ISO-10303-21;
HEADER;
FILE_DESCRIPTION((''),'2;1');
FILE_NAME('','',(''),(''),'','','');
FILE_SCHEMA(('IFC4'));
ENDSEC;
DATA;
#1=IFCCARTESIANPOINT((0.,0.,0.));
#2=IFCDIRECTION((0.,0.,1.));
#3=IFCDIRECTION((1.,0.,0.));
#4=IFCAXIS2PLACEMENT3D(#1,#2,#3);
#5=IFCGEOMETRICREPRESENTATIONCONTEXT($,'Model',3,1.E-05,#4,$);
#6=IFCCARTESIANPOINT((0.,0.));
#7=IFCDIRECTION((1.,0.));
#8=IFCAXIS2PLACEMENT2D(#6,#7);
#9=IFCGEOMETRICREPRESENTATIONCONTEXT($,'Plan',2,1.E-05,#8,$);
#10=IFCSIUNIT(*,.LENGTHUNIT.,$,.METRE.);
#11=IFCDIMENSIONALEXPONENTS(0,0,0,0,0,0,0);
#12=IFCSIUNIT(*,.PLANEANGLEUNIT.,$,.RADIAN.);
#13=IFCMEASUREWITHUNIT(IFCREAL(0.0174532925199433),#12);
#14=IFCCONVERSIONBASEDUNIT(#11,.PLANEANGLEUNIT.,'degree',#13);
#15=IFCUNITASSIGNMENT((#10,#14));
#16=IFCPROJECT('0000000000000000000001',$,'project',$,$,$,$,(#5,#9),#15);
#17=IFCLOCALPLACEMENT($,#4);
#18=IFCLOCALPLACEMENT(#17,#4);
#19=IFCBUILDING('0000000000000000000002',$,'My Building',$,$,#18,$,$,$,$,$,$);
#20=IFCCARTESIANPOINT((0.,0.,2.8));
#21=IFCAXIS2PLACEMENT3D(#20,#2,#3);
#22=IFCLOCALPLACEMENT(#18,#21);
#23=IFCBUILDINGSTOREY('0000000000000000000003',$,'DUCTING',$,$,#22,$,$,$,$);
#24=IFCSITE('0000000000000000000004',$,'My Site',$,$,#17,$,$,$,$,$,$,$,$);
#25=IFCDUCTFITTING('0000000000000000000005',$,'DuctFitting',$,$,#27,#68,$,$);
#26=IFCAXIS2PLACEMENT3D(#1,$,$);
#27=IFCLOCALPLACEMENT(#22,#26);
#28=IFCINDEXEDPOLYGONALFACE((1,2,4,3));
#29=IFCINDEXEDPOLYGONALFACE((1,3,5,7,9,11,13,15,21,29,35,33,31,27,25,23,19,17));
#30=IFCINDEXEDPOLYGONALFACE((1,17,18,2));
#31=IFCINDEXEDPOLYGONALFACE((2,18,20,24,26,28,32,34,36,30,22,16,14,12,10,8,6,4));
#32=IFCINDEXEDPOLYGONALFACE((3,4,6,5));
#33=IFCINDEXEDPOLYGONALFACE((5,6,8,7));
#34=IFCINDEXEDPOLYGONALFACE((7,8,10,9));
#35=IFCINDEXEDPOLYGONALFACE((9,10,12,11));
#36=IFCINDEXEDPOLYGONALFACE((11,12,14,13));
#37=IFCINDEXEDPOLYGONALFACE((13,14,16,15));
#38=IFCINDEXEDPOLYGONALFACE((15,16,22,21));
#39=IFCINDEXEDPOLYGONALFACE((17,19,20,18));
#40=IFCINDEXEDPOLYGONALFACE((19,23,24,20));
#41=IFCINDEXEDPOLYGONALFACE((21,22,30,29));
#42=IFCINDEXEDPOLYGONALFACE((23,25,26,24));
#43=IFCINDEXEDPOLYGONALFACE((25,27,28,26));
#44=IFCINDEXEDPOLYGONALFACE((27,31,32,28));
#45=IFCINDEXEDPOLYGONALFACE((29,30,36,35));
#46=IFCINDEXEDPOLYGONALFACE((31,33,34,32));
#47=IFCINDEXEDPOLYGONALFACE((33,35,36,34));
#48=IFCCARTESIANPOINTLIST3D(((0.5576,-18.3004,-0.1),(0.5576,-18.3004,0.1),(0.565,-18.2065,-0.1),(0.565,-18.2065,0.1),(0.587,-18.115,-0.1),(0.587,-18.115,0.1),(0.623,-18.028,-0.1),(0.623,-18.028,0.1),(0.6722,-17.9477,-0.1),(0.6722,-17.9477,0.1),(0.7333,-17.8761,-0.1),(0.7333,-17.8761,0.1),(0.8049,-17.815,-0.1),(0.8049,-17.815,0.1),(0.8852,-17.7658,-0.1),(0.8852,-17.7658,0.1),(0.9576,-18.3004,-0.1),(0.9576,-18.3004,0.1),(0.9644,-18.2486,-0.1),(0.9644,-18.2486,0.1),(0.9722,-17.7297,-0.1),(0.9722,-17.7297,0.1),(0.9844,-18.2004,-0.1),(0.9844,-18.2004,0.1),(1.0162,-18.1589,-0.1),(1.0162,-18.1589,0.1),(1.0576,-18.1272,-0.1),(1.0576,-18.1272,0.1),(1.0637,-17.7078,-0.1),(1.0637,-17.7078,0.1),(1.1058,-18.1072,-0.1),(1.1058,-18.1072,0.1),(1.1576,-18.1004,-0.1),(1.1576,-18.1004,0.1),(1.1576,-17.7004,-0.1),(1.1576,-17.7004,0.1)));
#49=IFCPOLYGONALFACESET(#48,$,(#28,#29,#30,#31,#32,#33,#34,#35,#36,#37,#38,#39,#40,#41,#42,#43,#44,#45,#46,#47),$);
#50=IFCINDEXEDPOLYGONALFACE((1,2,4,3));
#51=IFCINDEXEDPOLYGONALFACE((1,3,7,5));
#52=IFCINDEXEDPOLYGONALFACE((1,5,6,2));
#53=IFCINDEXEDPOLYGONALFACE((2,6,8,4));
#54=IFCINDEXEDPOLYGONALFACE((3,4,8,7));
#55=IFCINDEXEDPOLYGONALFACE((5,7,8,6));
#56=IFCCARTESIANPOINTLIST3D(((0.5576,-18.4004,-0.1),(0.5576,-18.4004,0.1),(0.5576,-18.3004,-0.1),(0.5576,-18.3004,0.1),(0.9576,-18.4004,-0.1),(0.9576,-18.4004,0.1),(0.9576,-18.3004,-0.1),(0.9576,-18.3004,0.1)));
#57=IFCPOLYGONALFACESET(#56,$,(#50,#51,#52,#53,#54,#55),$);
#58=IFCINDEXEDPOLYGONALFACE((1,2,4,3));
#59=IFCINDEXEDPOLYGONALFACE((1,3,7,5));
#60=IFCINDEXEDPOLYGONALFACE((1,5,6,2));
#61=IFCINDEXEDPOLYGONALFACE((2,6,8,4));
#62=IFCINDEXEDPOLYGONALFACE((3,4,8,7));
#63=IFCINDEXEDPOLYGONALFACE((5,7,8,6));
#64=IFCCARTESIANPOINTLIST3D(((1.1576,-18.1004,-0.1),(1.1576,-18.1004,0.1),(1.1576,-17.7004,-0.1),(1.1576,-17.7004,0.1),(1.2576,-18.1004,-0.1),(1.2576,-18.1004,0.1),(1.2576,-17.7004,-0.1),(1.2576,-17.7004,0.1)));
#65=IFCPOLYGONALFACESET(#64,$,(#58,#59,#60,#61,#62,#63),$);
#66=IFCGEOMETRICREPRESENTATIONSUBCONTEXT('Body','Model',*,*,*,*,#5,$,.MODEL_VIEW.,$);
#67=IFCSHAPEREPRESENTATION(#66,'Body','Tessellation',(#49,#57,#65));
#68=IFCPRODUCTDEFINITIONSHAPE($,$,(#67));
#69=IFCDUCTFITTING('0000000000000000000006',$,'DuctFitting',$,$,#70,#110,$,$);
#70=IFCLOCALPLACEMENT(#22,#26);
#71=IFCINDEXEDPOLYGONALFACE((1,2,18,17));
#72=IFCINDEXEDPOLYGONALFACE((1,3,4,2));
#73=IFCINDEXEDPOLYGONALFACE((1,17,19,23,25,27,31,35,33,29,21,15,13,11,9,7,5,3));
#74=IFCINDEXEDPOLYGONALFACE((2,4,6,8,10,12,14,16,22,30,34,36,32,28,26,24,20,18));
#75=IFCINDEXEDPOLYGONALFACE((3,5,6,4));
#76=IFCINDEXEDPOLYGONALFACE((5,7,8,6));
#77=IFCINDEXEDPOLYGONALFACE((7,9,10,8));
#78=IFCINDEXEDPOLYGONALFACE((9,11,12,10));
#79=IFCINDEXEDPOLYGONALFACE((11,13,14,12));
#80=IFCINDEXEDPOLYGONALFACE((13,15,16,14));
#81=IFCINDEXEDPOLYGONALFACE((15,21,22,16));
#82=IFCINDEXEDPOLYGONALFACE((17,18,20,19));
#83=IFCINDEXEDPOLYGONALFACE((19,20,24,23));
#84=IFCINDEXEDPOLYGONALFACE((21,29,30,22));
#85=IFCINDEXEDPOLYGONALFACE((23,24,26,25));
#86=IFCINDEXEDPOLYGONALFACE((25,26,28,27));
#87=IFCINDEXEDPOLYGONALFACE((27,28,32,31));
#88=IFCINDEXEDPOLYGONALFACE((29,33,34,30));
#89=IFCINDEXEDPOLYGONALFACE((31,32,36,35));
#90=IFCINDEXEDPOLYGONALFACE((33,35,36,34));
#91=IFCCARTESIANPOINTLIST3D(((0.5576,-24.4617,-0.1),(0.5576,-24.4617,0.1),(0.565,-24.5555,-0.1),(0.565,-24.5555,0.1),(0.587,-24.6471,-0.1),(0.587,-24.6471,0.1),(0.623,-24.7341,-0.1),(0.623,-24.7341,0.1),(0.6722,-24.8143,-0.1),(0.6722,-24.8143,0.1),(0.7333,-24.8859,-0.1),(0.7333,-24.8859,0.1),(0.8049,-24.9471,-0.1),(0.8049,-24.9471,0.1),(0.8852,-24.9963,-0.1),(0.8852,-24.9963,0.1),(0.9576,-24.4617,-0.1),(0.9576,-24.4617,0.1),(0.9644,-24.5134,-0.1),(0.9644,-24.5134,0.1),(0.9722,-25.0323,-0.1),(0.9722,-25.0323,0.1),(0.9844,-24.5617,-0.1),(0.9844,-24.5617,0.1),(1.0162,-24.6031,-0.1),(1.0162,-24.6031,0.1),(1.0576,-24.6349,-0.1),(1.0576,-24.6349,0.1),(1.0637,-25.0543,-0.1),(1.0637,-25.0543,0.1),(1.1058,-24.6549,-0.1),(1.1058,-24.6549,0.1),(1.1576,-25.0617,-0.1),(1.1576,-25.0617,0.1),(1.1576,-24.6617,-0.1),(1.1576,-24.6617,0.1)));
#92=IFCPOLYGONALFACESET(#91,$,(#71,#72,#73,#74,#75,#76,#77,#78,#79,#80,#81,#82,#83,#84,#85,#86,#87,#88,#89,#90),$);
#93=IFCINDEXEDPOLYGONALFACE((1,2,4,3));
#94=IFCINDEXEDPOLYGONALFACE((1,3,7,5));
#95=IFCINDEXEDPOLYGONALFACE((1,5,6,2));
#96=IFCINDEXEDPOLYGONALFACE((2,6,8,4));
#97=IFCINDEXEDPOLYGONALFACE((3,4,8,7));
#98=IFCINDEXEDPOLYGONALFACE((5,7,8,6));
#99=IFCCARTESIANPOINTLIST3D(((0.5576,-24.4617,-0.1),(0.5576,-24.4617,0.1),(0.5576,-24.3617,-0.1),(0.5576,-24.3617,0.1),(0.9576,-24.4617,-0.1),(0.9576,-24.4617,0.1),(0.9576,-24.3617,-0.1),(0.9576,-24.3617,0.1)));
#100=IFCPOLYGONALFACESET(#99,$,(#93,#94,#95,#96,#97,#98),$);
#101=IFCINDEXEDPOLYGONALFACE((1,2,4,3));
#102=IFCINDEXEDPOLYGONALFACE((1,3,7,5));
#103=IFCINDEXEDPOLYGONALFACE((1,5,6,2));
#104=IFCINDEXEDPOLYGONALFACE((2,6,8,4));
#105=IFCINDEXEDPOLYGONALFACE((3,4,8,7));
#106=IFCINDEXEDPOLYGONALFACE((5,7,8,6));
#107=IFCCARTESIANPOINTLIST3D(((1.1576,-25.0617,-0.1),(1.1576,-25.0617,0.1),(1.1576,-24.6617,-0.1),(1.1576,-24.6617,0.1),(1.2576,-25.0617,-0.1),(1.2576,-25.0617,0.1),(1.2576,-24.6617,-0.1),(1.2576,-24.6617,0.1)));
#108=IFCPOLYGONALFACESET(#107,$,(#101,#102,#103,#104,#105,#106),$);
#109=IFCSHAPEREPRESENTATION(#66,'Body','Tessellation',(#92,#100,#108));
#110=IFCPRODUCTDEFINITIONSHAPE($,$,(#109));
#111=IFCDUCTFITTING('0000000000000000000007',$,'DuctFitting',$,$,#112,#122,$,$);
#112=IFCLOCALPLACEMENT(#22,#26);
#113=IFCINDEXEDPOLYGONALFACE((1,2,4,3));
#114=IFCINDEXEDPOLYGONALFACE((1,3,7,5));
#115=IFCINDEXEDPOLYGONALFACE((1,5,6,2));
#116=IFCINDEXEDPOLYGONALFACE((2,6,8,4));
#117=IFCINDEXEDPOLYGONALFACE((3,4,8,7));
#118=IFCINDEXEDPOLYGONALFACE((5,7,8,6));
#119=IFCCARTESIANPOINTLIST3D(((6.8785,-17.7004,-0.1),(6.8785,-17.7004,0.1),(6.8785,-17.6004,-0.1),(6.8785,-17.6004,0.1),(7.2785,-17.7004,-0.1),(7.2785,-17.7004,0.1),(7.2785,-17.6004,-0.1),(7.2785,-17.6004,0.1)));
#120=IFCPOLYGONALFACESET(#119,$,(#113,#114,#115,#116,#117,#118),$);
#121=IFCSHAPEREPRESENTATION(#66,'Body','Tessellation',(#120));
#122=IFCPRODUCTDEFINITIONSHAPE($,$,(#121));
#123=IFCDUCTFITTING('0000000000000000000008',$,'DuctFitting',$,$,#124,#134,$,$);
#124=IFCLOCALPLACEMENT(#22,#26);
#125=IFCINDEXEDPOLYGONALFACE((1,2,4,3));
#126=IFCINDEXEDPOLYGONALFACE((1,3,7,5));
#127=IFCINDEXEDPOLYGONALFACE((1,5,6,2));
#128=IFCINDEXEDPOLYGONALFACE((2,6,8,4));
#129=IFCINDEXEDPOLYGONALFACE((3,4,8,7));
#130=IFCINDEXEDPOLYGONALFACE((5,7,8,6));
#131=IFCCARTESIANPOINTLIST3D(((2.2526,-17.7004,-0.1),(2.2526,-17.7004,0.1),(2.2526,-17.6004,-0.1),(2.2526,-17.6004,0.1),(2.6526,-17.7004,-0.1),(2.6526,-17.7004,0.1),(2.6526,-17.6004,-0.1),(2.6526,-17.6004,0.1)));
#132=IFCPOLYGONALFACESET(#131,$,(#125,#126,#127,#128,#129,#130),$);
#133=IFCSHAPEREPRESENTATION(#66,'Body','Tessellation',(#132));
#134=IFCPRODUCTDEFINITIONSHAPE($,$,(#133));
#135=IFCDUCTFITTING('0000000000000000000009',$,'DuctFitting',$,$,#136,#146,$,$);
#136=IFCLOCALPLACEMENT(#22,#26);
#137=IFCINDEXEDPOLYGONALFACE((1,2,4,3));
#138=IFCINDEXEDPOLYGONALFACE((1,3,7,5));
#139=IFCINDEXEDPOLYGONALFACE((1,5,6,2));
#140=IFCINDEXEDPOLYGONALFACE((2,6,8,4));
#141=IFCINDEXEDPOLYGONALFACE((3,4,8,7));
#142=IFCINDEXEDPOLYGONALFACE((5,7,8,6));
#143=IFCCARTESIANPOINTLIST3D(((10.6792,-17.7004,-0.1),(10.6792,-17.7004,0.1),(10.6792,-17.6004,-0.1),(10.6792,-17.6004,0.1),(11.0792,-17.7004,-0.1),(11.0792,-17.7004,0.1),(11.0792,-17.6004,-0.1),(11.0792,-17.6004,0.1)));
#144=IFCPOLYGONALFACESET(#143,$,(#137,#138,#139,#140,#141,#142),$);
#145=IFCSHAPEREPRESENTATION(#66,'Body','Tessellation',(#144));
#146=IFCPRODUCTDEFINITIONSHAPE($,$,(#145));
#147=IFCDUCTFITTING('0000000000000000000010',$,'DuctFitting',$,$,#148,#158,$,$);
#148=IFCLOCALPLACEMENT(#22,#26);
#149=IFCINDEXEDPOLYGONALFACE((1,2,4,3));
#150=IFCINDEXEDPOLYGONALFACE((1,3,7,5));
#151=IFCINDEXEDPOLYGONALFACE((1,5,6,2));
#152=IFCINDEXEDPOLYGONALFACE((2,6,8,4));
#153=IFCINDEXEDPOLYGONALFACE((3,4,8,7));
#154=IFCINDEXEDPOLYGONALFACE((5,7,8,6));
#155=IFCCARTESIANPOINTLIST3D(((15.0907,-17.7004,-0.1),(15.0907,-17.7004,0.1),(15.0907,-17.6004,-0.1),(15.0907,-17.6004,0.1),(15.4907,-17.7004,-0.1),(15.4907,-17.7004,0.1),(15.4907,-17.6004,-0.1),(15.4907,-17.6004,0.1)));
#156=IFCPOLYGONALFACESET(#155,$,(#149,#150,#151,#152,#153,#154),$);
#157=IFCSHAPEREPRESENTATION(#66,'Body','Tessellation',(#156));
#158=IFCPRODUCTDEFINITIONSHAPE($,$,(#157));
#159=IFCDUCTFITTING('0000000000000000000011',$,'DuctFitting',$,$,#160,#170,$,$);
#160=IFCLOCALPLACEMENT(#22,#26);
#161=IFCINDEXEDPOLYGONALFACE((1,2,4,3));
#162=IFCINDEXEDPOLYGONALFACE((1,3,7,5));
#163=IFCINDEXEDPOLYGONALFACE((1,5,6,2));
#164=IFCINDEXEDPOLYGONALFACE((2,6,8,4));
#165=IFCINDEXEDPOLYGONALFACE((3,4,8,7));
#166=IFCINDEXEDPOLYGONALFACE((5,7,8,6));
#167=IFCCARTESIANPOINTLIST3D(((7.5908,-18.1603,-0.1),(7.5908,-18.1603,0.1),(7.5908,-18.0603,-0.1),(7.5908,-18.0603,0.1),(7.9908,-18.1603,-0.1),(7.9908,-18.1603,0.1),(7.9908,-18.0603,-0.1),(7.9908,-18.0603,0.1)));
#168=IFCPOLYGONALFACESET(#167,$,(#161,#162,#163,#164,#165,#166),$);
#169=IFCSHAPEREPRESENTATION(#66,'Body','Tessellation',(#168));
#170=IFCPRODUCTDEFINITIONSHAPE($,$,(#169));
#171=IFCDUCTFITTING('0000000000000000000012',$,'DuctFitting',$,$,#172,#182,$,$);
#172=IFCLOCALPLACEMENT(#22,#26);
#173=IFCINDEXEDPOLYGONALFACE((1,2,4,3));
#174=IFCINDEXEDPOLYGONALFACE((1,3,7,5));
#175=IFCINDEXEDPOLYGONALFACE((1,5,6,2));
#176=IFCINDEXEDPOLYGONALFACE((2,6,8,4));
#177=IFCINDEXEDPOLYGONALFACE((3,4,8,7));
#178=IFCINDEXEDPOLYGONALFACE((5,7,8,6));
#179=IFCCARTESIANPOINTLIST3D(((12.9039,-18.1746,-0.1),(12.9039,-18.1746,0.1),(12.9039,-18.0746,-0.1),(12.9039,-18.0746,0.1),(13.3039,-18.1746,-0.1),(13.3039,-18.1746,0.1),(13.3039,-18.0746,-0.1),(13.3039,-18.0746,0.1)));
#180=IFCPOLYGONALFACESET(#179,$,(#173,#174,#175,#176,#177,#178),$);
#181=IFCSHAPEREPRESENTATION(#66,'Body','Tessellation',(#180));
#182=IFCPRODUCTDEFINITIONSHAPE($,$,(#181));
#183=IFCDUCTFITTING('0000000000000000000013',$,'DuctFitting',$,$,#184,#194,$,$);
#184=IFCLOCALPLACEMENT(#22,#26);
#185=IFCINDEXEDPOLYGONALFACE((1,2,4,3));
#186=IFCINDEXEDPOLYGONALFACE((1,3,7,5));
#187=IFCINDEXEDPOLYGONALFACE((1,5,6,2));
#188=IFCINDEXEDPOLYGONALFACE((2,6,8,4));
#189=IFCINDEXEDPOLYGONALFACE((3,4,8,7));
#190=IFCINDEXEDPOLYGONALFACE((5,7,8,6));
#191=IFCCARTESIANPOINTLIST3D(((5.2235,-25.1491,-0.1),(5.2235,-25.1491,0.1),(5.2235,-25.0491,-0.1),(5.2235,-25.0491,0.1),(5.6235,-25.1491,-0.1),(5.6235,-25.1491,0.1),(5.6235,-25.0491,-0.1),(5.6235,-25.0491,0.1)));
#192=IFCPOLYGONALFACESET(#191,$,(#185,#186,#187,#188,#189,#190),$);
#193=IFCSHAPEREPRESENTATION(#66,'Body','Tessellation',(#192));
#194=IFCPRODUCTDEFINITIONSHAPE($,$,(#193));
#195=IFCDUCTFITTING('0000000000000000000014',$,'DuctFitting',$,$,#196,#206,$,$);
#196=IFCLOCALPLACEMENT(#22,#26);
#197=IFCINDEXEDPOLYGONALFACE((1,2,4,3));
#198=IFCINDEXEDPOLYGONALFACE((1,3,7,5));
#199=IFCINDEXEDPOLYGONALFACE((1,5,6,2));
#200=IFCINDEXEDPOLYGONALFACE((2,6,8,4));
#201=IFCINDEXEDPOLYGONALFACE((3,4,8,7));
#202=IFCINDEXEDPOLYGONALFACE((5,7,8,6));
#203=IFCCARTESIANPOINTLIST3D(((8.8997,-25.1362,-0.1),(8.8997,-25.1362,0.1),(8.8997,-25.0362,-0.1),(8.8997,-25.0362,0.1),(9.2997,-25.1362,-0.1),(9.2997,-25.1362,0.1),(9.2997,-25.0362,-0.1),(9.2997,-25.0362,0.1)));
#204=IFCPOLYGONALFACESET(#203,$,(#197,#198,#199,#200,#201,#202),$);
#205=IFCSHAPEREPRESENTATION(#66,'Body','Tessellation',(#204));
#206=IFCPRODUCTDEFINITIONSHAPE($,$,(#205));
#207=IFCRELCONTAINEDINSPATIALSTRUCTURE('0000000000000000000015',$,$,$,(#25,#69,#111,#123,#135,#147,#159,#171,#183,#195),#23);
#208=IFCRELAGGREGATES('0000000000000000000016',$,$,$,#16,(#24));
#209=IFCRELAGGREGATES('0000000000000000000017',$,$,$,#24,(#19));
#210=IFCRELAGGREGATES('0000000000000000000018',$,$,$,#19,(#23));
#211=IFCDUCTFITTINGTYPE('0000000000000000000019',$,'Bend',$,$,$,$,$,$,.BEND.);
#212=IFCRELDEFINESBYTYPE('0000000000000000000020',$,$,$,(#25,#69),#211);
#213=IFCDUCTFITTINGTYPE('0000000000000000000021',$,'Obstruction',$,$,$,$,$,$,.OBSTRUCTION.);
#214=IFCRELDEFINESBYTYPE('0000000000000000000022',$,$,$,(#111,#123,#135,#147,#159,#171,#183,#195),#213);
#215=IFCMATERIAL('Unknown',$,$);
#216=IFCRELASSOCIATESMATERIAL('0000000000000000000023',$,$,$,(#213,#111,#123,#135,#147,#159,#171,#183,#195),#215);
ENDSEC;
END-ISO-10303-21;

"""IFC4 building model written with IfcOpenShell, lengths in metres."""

from ifc_helpers import new_model, entity, si_unit, converted_unit, frame, origin_with_axes, origin_2d_with_axis, place, context, subcontext, project, spatial, line, arc, indexed_curve, rectangle, outline, extrude, source, transform, mapped, material, material_profile, profile_set, profile_usage, type_object, type_shapes, element, save


model = new_model("IFC4")

# Units and contexts
model_context = context("Model", 3, precision=1e-05, world=origin_with_axes())
plan_context = context("Plan", 2, precision=1e-05, world=origin_2d_with_axis())
body_context = subcontext(model_context, "Body", "Model", "MODEL_VIEW")
ifc_project = project(units=[si_unit("LENGTHUNIT", "METRE"), converted_unit("PLANEANGLEUNIT", "degree", entity("IfcReal", 0.0174532925199433), si_unit("PLANEANGLEUNIT", "RADIAN"), dimensions=[0, 0, 0, 0, 0, 0, 0])], contexts=[model_context, plan_context])

# Site, building, storey
site_placement = place(None, origin_with_axes())
site = spatial("IfcSite", under=ifc_project, at=site_placement, Name="My Site")
building_placement = place(site_placement, origin_with_axes())
building = spatial("IfcBuilding", under=site, at=building_placement, Name="My Building")
storey_placement = place(building_placement, frame((0.0, 0.0, 2.8), z_axis=(0.0, 0.0, 1.0), x_axis=(1.0, 0.0, 0.0)))
storey = spatial("IfcBuildingStorey", under=building, at=storey_placement, Name="DUCTING")

# Shared definitions
ifc_material = material(Name="Unknown")

# Duct fittings
duct_fitting_type_1 = type_object("IfcDuctFittingType", Name="Bend", PredefinedType="BEND")
shared_shape = source(origin_with_axes(), body_context, "Body", "SweptSolid", [
    extrude(outline(indexed_curve([(-0.2, 0.0), (-0.2586, 0.1414), (-0.4, 0.2), (-0.4, 0.6), (0.0243, 0.4243), (0.2, 0.0)], segments=[arc(1, 2, 3), line(3, 4), arc(4, 5, 6), line(6, 1)])), frame((0.0, -0.1, 0.1), z_axis=(0.0, -1.0, 0.0), x_axis=(1.0, 0.0, 0.0)), (0.0, 0.0, -1.0), 0.2),
    extrude(rectangle(XDim=0.4, YDim=0.2), origin_with_axes(), (0.0, 0.0, 1.0), 0.1),
    extrude(rectangle(XDim=0.4, YDim=0.2), frame((-0.4, 0.0, 0.5), z_axis=(-1.0, 0.0, 0.0), x_axis=(0.0, 0.0, -1.0)), (0.0, 0.0, 1.0), 0.1),
])
type_shapes(duct_fitting_type_1, [shared_shape])
for number, where, z_axis, x_axis, name in (
    (1, (0.7576, -18.4004, 0.0), (0.0, 1.0, 0.0), (-1.0, 0.0, 0.0), "DuctFitting"),
    (2, (0.7576, -24.3617, 0.0), (0.0, -1.0, 0.0), (-1.0, 0.0, 0.0), "DuctFitting"),
):
    element("IfcDuctFitting", number, at=place(storey_placement, frame(where, z_axis=z_axis, x_axis=x_axis)), inside=storey, type_object=duct_fitting_type_1, Name=name, context=body_context, shape_type="MappedRepresentation", body=[
        mapped(shared_shape, transform((0.0, 0.0, 0.0), x_axis=(1.0, 0.0, 0.0), y_axis=(0.0, 1.0, 0.0), z_axis=(0.0, 0.0, 1.0), scale=1.0)),
    ])
ifc_material_profile_1 = material_profile(ifc_material, rectangle(XDim=0.4, YDim=0.2))
ifc_profile_set_1 = profile_set([ifc_material_profile_1])
ifc_profile_usage_1 = profile_usage(ifc_profile_set_1, cardinal=5)
duct_fitting_type_2 = type_object("IfcDuctFittingType", Name="Obstruction", PredefinedType="OBSTRUCTION", material=ifc_profile_set_1)
duct_fitting_1_placement = place(storey_placement, frame((7.0785, -17.7004, 0.0), z_axis=(0.0, 1.0, 0.0), x_axis=(-1.0, 0.0, 0.0)))
element("IfcDuctFitting", 3, at=duct_fitting_1_placement, inside=storey, type_object=duct_fitting_type_2, material=ifc_profile_usage_1, Name="DuctFitting", context=body_context, shape_type="SweptSolid", body=[
    extrude(rectangle(XDim=0.4, YDim=0.2), origin_with_axes(), (0.0, 0.0, 1.0), 0.1),
])
ifc_profile_usage_2 = profile_usage(ifc_profile_set_1, cardinal=5)
duct_fitting_2_placement = place(storey_placement, frame((2.4526, -17.7004, 0.0), z_axis=(0.0, 1.0, 0.0), x_axis=(-1.0, 0.0, 0.0)))
element("IfcDuctFitting", 4, at=duct_fitting_2_placement, inside=storey, type_object=duct_fitting_type_2, material=ifc_profile_usage_2, Name="DuctFitting", context=body_context, shape_type="SweptSolid", body=[
    extrude(rectangle(XDim=0.4, YDim=0.2), origin_with_axes(), (0.0, 0.0, 1.0), 0.1),
])
ifc_profile_usage_3 = profile_usage(ifc_profile_set_1, cardinal=5)
duct_fitting_3_placement = place(storey_placement, frame((10.8792, -17.7004, 0.0), z_axis=(0.0, 1.0, 0.0), x_axis=(-1.0, 0.0, 0.0)))
element("IfcDuctFitting", 5, at=duct_fitting_3_placement, inside=storey, type_object=duct_fitting_type_2, material=ifc_profile_usage_3, Name="DuctFitting", context=body_context, shape_type="SweptSolid", body=[
    extrude(rectangle(XDim=0.4, YDim=0.2), origin_with_axes(), (0.0, 0.0, 1.0), 0.1),
])
ifc_profile_usage_4 = profile_usage(ifc_profile_set_1, cardinal=5)
duct_fitting_4_placement = place(storey_placement, frame((15.2907, -17.7004, 0.0), z_axis=(0.0, 1.0, 0.0), x_axis=(-1.0, 0.0, 0.0)))
element("IfcDuctFitting", 6, at=duct_fitting_4_placement, inside=storey, type_object=duct_fitting_type_2, material=ifc_profile_usage_4, Name="DuctFitting", context=body_context, shape_type="SweptSolid", body=[
    extrude(rectangle(XDim=0.4, YDim=0.2), origin_with_axes(), (0.0, 0.0, 1.0), 0.1),
])
ifc_profile_usage_5 = profile_usage(ifc_profile_set_1, cardinal=5)
duct_fitting_5_placement = place(storey_placement, frame((7.7908, -18.1603, 0.0), z_axis=(-0.000001, 1.0, 0.0), x_axis=(-1.0, -0.000001, 0.0)))
element("IfcDuctFitting", 7, at=duct_fitting_5_placement, inside=storey, type_object=duct_fitting_type_2, material=ifc_profile_usage_5, Name="DuctFitting", context=body_context, shape_type="SweptSolid", body=[
    extrude(rectangle(XDim=0.4, YDim=0.2), origin_with_axes(), (0.0, 0.0, 1.0), 0.1),
])
ifc_profile_usage_6 = profile_usage(ifc_profile_set_1, cardinal=5)
duct_fitting_6_placement = place(storey_placement, frame((13.1039, -18.1746, 0.0), z_axis=(-0.000001, 1.0, 0.0), x_axis=(-1.0, -0.000001, 0.0)))
element("IfcDuctFitting", 8, at=duct_fitting_6_placement, inside=storey, type_object=duct_fitting_type_2, material=ifc_profile_usage_6, Name="DuctFitting", context=body_context, shape_type="SweptSolid", body=[
    extrude(rectangle(XDim=0.4, YDim=0.2), origin_with_axes(), (0.0, 0.0, 1.0), 0.1),
])
ifc_profile_usage_7 = profile_usage(ifc_profile_set_1, cardinal=5)
duct_fitting_7_placement = place(storey_placement, frame((5.4235, -25.0491, 0.0), z_axis=(0.0, -1.0, 0.0), x_axis=(1.0, 0.0, 0.0)))
element("IfcDuctFitting", 9, at=duct_fitting_7_placement, inside=storey, type_object=duct_fitting_type_2, material=ifc_profile_usage_7, Name="DuctFitting", context=body_context, shape_type="SweptSolid", body=[
    extrude(rectangle(XDim=0.4, YDim=0.2), origin_with_axes(), (0.0, 0.0, 1.0), 0.1),
])
ifc_profile_usage_8 = profile_usage(ifc_profile_set_1, cardinal=5)
duct_fitting_8_placement = place(storey_placement, frame((9.0997, -25.1362, 0.0), z_axis=(0.0, 1.0, 0.0), x_axis=(-1.0, 0.0, 0.0)))
element("IfcDuctFitting", 10, at=duct_fitting_8_placement, inside=storey, type_object=duct_fitting_type_2, material=ifc_profile_usage_8, Name="DuctFitting", context=body_context, shape_type="SweptSolid", body=[
    extrude(rectangle(XDim=0.4, YDim=0.2), origin_with_axes(), (0.0, 0.0, 1.0), 0.1),
])

save(model, "model.ifc")
